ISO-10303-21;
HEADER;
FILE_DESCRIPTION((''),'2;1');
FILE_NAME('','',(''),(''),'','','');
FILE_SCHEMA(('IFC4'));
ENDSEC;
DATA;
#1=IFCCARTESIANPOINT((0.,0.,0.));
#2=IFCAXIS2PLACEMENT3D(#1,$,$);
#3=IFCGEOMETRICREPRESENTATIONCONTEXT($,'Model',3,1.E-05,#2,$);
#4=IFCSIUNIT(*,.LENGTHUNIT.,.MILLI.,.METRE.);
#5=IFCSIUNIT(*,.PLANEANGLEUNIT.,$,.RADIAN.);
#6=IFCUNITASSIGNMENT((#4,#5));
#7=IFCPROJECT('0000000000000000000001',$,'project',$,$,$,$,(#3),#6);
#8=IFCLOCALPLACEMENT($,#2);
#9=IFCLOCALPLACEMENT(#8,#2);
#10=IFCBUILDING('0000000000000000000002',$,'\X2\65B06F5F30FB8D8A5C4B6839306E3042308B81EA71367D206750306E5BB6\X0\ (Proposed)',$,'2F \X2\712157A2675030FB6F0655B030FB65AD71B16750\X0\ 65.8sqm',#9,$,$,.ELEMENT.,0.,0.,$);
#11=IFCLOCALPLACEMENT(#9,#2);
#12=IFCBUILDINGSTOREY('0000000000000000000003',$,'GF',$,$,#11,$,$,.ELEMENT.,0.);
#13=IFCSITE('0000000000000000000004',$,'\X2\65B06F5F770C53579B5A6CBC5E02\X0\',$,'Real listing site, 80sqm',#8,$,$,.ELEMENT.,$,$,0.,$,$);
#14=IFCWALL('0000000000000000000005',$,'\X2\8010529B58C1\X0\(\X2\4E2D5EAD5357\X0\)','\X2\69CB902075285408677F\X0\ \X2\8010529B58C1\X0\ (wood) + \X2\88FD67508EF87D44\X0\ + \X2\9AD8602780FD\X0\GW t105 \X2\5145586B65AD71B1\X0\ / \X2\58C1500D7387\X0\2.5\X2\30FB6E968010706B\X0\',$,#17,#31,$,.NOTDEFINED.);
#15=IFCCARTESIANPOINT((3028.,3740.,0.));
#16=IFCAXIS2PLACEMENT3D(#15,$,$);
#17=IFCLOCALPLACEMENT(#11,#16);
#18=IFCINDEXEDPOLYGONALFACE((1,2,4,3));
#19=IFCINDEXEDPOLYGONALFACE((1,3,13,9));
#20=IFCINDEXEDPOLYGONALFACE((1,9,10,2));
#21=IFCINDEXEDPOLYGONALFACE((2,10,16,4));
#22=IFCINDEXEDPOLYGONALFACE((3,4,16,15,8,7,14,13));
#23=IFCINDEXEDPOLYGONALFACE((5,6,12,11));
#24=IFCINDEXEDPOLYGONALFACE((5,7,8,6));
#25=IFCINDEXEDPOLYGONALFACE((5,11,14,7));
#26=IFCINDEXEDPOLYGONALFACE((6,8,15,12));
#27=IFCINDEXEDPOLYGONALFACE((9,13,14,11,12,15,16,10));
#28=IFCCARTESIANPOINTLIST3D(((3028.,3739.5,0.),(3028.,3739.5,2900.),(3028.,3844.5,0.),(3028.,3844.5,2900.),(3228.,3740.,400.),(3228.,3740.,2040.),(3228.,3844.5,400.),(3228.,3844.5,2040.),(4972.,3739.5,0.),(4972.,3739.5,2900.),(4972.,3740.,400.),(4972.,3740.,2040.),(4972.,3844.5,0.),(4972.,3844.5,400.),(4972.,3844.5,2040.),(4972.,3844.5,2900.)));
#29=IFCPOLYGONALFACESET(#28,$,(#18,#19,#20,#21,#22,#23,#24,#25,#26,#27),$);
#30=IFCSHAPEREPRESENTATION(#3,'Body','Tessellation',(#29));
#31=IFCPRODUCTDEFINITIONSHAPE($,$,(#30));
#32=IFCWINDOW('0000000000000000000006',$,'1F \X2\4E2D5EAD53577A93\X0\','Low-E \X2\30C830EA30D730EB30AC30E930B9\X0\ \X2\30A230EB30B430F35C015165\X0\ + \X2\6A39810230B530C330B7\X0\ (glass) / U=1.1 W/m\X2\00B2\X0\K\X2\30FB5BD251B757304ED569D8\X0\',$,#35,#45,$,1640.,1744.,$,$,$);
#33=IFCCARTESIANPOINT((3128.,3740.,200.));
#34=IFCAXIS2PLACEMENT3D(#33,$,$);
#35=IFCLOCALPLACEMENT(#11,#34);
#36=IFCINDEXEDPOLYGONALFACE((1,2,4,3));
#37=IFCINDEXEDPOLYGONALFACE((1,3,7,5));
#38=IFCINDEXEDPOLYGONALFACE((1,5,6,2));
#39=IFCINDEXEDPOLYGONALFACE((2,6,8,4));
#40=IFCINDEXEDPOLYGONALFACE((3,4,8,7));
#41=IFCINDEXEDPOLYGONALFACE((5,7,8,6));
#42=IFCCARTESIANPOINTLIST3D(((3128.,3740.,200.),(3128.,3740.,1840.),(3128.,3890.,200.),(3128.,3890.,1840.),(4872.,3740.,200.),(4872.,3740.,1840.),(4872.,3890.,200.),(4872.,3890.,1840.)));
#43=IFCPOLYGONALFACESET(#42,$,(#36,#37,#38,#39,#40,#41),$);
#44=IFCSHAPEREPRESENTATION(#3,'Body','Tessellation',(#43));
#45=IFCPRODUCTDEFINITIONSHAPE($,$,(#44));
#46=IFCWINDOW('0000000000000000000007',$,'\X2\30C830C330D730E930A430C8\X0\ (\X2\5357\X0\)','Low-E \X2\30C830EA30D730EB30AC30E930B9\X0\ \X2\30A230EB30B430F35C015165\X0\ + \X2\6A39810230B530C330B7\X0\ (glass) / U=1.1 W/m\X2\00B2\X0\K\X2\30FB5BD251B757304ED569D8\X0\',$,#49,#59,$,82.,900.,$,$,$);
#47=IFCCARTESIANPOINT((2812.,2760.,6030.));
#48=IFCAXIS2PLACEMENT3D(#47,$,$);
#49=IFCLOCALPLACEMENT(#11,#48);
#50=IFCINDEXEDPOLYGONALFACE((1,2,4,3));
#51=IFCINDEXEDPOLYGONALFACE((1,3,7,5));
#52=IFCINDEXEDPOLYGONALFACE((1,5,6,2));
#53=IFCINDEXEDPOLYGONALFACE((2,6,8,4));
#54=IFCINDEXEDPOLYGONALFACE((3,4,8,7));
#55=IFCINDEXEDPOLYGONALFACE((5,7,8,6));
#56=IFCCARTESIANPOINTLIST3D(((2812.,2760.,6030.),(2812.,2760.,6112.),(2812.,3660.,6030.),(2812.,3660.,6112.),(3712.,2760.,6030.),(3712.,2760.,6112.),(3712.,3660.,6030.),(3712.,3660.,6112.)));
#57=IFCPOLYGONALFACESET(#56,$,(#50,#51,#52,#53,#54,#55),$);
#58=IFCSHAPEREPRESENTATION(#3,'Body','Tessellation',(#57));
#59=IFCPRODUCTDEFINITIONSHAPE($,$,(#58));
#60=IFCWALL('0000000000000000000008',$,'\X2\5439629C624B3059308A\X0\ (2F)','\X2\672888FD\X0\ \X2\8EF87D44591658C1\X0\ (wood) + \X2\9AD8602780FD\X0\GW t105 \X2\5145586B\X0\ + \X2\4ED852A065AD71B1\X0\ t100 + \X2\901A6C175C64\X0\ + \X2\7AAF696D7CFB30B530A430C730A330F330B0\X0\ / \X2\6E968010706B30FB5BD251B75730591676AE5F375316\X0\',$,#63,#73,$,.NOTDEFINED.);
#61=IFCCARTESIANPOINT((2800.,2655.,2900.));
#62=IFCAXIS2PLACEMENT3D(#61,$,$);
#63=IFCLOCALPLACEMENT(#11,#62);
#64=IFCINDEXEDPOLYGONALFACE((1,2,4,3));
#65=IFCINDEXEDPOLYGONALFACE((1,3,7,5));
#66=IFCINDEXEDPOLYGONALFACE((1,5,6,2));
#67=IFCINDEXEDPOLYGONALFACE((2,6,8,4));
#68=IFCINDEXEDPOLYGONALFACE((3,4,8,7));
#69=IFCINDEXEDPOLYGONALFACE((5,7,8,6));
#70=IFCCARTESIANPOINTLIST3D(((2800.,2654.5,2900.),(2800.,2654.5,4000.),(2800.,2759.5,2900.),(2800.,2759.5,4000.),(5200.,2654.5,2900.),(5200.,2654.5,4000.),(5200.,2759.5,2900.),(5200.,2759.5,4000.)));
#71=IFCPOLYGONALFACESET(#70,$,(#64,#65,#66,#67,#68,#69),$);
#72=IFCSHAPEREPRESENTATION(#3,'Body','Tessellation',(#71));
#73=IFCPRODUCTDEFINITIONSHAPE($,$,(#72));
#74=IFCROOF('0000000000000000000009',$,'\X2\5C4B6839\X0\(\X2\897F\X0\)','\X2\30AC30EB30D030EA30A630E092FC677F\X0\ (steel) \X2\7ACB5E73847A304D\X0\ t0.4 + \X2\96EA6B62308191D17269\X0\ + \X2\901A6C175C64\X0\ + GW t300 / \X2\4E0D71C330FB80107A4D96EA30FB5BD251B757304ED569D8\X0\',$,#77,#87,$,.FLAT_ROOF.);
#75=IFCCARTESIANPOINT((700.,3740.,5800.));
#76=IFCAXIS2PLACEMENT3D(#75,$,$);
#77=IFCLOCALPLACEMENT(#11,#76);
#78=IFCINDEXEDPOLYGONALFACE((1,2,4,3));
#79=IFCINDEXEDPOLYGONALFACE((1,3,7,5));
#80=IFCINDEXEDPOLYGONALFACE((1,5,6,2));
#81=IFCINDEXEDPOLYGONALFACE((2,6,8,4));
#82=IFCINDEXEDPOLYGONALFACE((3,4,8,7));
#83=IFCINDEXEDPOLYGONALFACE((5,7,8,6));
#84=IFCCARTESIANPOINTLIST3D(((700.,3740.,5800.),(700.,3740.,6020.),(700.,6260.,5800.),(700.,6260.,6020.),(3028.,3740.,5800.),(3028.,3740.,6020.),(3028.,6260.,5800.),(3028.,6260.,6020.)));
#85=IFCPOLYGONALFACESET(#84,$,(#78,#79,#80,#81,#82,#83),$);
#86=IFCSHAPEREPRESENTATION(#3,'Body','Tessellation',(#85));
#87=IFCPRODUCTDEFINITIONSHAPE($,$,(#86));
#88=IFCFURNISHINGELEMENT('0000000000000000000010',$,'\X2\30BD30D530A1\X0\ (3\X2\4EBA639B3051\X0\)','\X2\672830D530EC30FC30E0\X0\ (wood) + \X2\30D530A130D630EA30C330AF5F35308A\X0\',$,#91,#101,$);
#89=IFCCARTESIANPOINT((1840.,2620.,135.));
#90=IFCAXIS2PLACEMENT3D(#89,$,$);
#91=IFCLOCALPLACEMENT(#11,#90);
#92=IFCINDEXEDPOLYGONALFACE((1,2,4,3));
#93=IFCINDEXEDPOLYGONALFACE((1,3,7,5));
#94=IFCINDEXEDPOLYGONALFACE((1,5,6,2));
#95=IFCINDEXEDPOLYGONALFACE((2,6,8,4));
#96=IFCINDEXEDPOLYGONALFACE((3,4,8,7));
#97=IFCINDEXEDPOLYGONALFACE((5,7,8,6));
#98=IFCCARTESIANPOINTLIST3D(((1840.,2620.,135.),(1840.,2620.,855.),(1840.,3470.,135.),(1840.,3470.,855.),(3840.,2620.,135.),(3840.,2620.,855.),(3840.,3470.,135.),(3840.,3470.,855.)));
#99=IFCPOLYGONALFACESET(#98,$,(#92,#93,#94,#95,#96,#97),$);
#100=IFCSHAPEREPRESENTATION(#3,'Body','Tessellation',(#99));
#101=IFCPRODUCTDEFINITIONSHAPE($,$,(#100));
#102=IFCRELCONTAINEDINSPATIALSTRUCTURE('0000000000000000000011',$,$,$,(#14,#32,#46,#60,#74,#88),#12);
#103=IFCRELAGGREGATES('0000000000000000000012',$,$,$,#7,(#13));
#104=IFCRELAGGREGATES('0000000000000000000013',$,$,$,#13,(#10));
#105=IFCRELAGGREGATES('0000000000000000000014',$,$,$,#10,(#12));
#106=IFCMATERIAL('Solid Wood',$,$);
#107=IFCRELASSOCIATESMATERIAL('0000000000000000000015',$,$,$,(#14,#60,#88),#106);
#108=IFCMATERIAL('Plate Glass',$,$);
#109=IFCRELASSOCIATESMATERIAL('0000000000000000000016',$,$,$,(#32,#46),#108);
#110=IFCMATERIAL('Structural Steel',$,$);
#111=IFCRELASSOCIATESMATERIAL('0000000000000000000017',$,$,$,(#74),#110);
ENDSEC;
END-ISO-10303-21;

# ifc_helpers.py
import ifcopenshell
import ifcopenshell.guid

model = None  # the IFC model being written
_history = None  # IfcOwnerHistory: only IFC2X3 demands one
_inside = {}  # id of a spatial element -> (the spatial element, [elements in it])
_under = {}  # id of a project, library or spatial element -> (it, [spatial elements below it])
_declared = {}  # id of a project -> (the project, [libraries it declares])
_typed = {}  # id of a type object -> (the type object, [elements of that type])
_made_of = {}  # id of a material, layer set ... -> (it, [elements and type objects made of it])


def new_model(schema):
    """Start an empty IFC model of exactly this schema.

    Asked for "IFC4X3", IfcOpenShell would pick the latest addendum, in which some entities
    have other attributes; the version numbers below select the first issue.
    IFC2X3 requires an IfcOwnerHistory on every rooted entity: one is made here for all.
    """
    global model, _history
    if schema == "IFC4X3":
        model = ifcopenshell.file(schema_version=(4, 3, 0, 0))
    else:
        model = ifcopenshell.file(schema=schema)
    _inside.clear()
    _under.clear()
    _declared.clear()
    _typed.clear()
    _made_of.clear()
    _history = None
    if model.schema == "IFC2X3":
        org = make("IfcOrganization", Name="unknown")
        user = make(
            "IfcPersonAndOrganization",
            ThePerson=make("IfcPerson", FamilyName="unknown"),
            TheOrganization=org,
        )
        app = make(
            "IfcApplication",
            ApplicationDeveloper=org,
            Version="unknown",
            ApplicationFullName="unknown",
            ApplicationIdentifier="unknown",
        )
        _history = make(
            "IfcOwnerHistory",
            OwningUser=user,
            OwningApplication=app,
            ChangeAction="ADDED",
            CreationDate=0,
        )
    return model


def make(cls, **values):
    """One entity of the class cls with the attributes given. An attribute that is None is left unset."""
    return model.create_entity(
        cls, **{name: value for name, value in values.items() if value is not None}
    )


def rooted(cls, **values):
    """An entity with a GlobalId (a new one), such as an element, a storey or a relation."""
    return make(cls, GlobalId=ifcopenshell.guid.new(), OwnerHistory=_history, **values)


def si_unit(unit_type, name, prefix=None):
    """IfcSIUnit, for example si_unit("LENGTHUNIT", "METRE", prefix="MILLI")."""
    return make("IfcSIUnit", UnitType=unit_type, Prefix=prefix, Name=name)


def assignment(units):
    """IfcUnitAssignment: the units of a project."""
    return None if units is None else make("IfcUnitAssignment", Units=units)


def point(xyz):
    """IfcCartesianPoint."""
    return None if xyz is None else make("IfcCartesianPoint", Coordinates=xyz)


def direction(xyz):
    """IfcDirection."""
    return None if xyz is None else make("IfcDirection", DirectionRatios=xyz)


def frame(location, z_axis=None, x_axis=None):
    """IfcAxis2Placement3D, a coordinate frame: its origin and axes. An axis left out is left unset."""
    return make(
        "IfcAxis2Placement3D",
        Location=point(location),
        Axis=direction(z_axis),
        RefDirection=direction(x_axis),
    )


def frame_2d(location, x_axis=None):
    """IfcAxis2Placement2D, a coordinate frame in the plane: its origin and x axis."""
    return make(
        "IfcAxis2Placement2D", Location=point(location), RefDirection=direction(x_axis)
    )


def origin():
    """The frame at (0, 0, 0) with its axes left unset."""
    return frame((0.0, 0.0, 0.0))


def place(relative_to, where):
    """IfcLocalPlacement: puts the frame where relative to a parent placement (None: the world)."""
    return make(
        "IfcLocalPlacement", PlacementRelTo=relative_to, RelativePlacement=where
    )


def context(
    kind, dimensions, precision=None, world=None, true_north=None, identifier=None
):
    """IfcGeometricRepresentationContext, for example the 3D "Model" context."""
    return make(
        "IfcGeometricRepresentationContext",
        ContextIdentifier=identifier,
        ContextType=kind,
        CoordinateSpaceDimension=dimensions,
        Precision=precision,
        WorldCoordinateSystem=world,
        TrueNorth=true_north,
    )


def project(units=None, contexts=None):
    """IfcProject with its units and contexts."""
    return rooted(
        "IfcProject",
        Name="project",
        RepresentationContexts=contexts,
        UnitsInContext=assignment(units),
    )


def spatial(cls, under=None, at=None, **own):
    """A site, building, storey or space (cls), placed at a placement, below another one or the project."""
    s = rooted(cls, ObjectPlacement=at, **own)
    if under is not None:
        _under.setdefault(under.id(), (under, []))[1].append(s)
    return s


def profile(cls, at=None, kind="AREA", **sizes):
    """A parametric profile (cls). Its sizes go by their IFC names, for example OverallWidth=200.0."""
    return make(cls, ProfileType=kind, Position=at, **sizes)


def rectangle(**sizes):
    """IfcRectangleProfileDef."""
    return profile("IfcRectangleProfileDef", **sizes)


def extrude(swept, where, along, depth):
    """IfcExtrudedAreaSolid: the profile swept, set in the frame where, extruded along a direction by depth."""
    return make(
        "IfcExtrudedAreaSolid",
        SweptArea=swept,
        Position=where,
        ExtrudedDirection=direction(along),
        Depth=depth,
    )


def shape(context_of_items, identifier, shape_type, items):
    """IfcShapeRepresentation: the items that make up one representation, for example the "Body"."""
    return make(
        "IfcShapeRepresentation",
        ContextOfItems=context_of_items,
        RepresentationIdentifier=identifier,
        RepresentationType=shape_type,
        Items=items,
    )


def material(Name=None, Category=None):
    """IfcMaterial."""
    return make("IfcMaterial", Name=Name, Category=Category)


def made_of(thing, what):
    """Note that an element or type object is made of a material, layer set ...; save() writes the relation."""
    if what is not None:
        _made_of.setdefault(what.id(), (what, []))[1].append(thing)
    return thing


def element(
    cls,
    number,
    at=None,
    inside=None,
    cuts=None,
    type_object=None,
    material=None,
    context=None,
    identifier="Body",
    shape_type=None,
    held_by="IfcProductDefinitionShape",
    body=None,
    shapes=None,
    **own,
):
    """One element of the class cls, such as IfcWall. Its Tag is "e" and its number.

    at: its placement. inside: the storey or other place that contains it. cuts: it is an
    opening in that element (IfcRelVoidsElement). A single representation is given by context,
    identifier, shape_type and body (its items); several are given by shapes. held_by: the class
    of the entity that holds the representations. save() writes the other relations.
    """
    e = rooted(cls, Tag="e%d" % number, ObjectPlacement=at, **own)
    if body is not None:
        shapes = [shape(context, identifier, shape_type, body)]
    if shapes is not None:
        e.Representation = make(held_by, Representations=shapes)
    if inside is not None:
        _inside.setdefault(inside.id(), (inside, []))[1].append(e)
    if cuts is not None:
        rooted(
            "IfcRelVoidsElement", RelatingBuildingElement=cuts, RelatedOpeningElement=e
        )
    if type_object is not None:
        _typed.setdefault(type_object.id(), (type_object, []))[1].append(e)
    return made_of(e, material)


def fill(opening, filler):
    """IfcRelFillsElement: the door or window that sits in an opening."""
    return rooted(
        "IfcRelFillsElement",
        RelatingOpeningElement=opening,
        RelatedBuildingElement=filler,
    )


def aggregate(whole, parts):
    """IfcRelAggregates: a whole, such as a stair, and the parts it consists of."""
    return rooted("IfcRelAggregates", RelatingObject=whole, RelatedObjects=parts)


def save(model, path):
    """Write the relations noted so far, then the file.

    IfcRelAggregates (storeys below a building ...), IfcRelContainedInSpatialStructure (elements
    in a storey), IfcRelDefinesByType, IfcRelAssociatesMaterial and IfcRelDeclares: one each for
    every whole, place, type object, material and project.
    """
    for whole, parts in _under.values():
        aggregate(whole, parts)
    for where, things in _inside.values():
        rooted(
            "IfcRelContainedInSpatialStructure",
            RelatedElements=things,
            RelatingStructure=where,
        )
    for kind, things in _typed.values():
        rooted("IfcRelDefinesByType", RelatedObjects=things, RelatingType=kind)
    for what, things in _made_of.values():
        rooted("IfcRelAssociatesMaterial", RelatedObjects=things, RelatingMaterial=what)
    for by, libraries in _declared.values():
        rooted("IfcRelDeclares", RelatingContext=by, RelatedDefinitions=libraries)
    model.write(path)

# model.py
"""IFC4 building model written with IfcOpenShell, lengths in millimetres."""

from ifc_helpers import new_model, si_unit, frame, frame_2d, origin, place, context, project, spatial, rectangle, extrude, material, element, fill, save


model = new_model("IFC4")

# Units and contexts
model_context = context("Model", 3, precision=1e-05, world=origin())
ifc_project = project(units=[si_unit("LENGTHUNIT", "METRE", prefix="MILLI"), si_unit("PLANEANGLEUNIT", "RADIAN")], contexts=[model_context])

# Site, building, storey
site_placement = place(None, origin())
site = spatial("IfcSite", under=ifc_project, at=site_placement, Name="新潟県南魚沼市", ObjectType="Real listing site, 80sqm", CompositionType="ELEMENT", RefElevation=0.0)
building_placement = place(site_placement, origin())
building = spatial("IfcBuilding", under=site, at=building_placement, Name="新潟・越屋根のある自然素材の家 (Proposed)", ObjectType="2F 無垢材・漆喰・断熱材 65.8sqm", CompositionType="ELEMENT", ElevationOfRefHeight=0.0, ElevationOfTerrain=0.0)
storey_placement = place(building_placement, origin())
storey = spatial("IfcBuildingStorey", under=building, at=storey_placement, Name="GF", CompositionType="ELEMENT", Elevation=0.0)

# Shared definitions
ifc_material_1 = material(Name="Solid Wood")

# Wall, opening, window
wall_1_placement = place(storey_placement, frame((3028.0, 3740.0, 0.0)))
wall_1 = element("IfcWall", 1, at=wall_1_placement, inside=storey, material=ifc_material_1, Name="耐力壁(中庭南)", Description="構造用合板 耐力壁 (wood) + 製材軸組 + 高性能GW t105 充填断熱 / 壁倍率2.5・準耐火", PredefinedType="NOTDEFINED", context=model_context, shape_type="SweptSolid", body=[
    extrude(rectangle(XDim=1944.0, YDim=105.0, at=frame_2d((972.0, 52.0))), frame((3028.0, 3740.0, 0.0)), (0.0, 0.0, 1.0), 2900.0),
])
opening_placement = place(storey_placement, frame((3128.0, 3740.0, 200.0)))
opening = element("IfcOpeningElement", 2, at=opening_placement, cuts=wall_1, PredefinedType="NOTDEFINED", context=model_context, shape_type="SweptSolid", body=[
    extrude(rectangle(XDim=1744.0, YDim=150.0, at=frame_2d((872.0, 75.0))), frame((3128.0, 3740.0, 200.0)), (0.0, 0.0, 1.0), 1640.0),
])
ifc_material_2 = material(Name="Plate Glass")
window_1_placement = place(storey_placement, frame((3128.0, 3740.0, 200.0)))
window_1 = element("IfcWindow", 3, at=window_1_placement, inside=storey, material=ifc_material_2, Name="1F 中庭南窓", Description="Low-E トリプルガラス アルゴン封入 + 樹脂サッシ (glass) / U=1.1 W/m²K・寒冷地仕様", OverallHeight=1640.0, OverallWidth=1744.0, context=model_context, shape_type="SweptSolid", body=[
    extrude(rectangle(XDim=1744.0, YDim=150.0, at=frame_2d((872.0, 75.0))), frame((3128.0, 3740.0, 200.0)), (0.0, 0.0, 1.0), 1640.0),
])
fill(opening, window_1)

# Window
window_2_placement = place(storey_placement, frame((2812.0, 2760.0, 6030.0)))
element("IfcWindow", 4, at=window_2_placement, inside=storey, material=ifc_material_2, Name="トップライト (南)", Description="Low-E トリプルガラス アルゴン封入 + 樹脂サッシ (glass) / U=1.1 W/m²K・寒冷地仕様", OverallHeight=82.0, OverallWidth=900.0, context=model_context, shape_type="SweptSolid", body=[
    extrude(rectangle(XDim=900.0, YDim=900.0, at=frame_2d((450.0, 450.0))), frame((2812.0, 2760.0, 6030.0)), (0.0, 0.0, 1.0), 82.0),
])

# Wall
wall_2_placement = place(storey_placement, frame((2800.0, 2655.0, 2900.0)))
element("IfcWall", 5, at=wall_2_placement, inside=storey, material=ifc_material_1, Name="吹抜手すり (2F)", Description="木製 軸組外壁 (wood) + 高性能GW t105 充填 + 付加断熱 t100 + 通気層 + 窯業系サイディング / 準耐火・寒冷地外皮強化", PredefinedType="NOTDEFINED", context=model_context, shape_type="SweptSolid", body=[
    extrude(rectangle(XDim=2400.0, YDim=105.0, at=frame_2d((1200.0, 52.0))), frame((2800.0, 2655.0, 2900.0)), (0.0, 0.0, 1.0), 1100.0),
])

# Roof
ifc_material_3 = material(Name="Structural Steel")
for number, where, name in (
    (6, (700.0, 3740.0, 5800.0), "屋根(西)"),
):
    element("IfcRoof", number, at=place(storey_placement, frame(where)), inside=storey, material=ifc_material_3, Name=name, Description="ガルバリウム鋼板 (steel) 立平葺き t0.4 + 雪止め金物 + 通気層 + GW t300 / 不燃・耐積雪・寒冷地仕様", PredefinedType="FLAT_ROOF", context=model_context, shape_type="SweptSolid", body=[
        extrude(rectangle(XDim=2328.0, YDim=2520.0, at=frame_2d((1164.0, 1260.0))), frame((700.0, 3740.0, 5800.0)), (0.0, 0.0, 1.0), 220.0),
    ])

# Furnishing element
furnishing_placement = place(storey_placement, frame((1840.0, 2620.0, 135.0)))
element("IfcFurnishingElement", 7, at=furnishing_placement, inside=storey, material=ifc_material_1, Name="ソファ (3人掛け)", Description="木フレーム (wood) + ファブリック張り", context=model_context, shape_type="SweptSolid", body=[
    extrude(rectangle(XDim=2000.0, YDim=850.0, at=frame_2d((1000.0, 425.0))), frame((1840.0, 2620.0, 135.0)), (0.0, 0.0, 1.0), 720.0),
])

save(model, "model.ifc")
